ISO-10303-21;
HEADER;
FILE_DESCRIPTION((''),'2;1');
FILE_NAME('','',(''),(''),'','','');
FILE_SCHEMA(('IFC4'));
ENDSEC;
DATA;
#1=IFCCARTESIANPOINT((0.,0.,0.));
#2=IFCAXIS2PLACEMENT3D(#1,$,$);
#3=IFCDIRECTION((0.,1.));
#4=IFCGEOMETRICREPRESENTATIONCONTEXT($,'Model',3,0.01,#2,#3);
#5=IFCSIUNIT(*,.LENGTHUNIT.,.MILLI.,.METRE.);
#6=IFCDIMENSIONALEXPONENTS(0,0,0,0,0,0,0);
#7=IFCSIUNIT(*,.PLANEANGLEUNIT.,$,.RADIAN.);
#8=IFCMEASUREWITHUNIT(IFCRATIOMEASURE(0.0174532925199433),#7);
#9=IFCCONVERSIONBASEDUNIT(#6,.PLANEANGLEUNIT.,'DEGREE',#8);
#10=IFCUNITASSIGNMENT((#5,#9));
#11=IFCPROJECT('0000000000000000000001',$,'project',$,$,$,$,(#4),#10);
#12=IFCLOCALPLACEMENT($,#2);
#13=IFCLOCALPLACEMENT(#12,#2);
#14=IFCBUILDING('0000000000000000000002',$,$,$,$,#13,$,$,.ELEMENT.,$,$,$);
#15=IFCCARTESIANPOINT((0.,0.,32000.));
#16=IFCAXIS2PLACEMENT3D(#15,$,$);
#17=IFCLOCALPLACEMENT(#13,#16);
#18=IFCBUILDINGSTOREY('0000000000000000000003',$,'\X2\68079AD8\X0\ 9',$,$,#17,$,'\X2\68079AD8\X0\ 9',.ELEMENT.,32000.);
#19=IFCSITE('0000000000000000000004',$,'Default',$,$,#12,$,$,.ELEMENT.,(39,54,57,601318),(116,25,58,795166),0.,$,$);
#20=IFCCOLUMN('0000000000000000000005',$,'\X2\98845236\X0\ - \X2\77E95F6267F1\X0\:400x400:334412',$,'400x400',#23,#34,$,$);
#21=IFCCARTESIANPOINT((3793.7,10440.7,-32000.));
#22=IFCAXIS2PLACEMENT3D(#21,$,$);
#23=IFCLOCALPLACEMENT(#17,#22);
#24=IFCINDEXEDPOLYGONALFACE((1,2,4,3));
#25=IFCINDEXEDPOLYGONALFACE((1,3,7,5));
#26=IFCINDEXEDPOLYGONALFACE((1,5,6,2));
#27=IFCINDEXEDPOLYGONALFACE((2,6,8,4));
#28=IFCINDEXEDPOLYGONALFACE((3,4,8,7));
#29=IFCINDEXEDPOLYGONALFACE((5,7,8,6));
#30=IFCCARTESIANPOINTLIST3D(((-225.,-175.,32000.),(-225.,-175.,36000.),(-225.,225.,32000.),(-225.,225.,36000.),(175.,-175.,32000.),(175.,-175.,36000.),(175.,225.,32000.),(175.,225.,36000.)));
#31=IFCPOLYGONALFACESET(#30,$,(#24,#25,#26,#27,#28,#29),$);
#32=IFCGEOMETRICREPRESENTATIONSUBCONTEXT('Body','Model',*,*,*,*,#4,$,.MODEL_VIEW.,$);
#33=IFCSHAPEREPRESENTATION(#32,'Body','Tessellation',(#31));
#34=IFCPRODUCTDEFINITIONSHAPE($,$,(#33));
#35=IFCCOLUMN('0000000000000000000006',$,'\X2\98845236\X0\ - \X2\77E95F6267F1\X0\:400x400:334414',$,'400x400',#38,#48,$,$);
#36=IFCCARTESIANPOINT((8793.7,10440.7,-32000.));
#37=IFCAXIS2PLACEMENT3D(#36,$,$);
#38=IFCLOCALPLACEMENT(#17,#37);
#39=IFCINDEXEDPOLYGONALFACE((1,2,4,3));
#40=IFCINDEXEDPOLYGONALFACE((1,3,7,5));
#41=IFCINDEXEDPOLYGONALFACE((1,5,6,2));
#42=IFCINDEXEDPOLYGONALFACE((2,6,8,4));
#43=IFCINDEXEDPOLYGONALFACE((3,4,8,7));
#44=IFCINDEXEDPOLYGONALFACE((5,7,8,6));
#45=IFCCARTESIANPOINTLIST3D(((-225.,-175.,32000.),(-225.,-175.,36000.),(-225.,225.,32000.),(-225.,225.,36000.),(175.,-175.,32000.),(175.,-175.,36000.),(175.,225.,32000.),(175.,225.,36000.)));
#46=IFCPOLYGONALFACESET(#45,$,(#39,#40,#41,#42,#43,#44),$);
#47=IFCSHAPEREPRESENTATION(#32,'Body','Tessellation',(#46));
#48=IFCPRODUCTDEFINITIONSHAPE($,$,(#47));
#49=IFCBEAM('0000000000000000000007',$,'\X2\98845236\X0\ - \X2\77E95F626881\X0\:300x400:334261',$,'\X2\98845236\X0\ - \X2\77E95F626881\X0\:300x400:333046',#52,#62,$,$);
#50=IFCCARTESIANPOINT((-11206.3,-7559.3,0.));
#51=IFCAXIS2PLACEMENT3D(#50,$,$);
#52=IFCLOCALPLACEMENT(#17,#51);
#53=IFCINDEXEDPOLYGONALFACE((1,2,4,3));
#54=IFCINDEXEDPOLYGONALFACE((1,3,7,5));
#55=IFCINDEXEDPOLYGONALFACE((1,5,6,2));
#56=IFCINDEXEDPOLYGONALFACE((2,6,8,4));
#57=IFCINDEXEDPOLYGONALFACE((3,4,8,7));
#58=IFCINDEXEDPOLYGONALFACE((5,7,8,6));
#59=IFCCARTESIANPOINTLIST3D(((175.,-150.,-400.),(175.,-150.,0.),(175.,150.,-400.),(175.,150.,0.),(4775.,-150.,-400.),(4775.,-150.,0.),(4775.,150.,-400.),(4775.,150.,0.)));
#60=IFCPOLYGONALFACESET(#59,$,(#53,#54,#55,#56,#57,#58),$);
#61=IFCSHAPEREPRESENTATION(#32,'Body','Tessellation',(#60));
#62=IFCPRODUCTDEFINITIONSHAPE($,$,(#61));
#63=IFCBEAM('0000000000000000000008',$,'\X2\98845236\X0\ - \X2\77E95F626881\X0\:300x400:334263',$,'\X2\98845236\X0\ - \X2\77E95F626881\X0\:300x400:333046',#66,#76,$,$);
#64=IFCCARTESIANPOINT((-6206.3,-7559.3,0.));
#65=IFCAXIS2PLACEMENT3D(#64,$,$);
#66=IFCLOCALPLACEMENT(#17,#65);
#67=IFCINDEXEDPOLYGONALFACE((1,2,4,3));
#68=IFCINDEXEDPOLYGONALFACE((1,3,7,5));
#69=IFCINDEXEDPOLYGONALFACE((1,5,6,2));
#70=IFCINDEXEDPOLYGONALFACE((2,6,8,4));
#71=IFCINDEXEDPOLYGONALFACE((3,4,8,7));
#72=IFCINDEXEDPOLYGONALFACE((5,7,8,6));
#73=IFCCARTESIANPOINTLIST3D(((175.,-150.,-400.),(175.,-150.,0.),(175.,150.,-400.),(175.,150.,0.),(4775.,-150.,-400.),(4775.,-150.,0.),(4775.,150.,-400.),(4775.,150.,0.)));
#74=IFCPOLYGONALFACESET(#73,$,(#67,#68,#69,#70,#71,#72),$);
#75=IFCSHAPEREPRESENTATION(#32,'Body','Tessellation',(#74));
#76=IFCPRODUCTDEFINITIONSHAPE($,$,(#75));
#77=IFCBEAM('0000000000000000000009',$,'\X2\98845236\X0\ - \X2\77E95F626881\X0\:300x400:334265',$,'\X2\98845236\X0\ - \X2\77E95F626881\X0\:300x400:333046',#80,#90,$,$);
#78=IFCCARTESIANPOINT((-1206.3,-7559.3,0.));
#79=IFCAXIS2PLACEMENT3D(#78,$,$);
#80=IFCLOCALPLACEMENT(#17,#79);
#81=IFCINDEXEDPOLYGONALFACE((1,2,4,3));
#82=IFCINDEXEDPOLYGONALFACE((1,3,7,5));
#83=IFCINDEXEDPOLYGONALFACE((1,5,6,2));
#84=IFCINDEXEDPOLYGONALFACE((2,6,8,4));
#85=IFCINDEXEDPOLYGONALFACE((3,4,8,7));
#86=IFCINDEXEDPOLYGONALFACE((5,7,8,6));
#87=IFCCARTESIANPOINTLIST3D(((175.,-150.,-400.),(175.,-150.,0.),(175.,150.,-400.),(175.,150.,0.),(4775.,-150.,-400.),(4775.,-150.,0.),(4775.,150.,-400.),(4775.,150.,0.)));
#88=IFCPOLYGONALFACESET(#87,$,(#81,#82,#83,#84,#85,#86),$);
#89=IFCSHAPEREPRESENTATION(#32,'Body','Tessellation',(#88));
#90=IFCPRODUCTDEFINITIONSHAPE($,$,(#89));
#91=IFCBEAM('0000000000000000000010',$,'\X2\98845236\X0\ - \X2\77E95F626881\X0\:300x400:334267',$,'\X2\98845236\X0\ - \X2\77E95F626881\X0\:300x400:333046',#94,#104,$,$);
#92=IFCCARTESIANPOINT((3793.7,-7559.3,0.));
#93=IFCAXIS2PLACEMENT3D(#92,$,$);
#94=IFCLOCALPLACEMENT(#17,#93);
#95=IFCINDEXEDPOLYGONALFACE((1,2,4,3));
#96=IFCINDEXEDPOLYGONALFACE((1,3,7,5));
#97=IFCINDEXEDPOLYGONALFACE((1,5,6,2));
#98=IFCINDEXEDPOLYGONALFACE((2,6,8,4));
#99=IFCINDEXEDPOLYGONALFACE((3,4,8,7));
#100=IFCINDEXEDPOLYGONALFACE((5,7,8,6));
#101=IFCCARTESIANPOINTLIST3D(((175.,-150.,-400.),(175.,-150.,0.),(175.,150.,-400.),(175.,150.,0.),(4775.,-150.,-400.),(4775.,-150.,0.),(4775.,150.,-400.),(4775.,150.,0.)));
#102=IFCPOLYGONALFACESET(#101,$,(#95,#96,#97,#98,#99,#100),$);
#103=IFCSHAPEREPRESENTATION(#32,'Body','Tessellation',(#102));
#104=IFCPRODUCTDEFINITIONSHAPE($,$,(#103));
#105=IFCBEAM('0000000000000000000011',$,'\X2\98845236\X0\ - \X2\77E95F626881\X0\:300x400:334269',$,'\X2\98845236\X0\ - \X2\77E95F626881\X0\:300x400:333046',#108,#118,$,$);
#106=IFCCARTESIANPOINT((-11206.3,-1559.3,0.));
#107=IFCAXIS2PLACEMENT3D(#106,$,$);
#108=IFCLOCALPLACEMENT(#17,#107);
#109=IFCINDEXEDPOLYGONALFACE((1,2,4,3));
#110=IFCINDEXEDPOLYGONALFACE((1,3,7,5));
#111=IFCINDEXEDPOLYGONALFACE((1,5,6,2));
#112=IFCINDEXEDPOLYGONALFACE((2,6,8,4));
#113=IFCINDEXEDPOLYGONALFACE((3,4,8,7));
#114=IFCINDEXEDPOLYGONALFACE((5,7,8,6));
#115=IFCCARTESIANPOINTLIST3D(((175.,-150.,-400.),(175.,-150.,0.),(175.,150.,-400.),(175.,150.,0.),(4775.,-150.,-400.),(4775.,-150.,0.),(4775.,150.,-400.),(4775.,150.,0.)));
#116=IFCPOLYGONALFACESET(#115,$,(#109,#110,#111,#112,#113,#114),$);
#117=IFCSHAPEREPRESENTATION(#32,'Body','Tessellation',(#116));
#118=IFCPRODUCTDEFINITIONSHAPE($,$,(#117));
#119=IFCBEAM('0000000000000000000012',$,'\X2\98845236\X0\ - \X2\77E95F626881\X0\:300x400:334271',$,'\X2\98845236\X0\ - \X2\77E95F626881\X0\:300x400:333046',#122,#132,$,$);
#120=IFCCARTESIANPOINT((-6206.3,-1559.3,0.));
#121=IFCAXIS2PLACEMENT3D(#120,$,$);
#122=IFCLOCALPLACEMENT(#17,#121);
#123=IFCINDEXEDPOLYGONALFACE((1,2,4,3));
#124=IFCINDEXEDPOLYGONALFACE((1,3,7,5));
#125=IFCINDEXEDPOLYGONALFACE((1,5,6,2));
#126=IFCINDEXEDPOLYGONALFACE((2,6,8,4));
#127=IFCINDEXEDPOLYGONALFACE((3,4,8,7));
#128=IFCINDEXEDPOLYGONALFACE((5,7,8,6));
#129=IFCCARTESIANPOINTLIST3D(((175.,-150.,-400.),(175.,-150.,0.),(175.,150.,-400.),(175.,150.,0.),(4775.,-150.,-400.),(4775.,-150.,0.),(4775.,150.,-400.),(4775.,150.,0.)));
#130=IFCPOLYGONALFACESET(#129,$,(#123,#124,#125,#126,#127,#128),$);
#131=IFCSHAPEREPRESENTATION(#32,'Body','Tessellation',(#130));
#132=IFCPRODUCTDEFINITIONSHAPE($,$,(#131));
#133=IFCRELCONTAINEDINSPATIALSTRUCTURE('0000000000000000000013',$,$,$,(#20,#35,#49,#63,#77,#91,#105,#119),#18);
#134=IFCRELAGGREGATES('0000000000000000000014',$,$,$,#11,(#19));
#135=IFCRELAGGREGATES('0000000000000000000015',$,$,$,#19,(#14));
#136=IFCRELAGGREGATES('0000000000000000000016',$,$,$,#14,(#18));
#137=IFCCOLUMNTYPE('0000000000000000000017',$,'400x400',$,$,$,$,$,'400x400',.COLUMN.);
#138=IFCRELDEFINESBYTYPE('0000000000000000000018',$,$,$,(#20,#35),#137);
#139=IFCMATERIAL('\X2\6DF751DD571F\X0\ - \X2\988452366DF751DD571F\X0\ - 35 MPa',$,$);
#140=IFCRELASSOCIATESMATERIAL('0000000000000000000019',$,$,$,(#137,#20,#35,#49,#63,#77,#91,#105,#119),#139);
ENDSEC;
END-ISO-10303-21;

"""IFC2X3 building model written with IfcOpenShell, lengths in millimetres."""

from ifc_helpers import new_model, entity, si_unit, converted_unit, direction, frame, frame_2d, origin, place, context, subcontext, project, spatial, rectangle, extrude, source, transform, mapped, material, type_object, type_shapes, element, save


model = new_model("IFC2X3")

# Units and contexts
model_context = context("Model", 3, precision=0.01, world=origin(), true_north=direction((0.0, 1.0)))
body_context = subcontext(model_context, "Body", "Model", "MODEL_VIEW")
ifc_project = project(units=[si_unit("LENGTHUNIT", "METRE", prefix="MILLI"), converted_unit("PLANEANGLEUNIT", "DEGREE", entity("IfcRatioMeasure", 0.0174532925199433), si_unit("PLANEANGLEUNIT", "RADIAN"), dimensions=[0, 0, 0, 0, 0, 0, 0])], contexts=[model_context])

# Site, building, storey
site_placement = place(None, origin())
site = spatial("IfcSite", under=ifc_project, at=site_placement, Name="Default", CompositionType="ELEMENT", RefLatitude=(39, 54, 57, 601318), RefLongitude=(116, 25, 58, 795166), RefElevation=0.0)
building_placement = place(site_placement, origin())
building = spatial("IfcBuilding", under=site, at=building_placement, CompositionType="ELEMENT")
storey_placement = place(building_placement, frame((0.0, 0.0, 32000.0)))
storey = spatial("IfcBuildingStorey", under=building, at=storey_placement, Name="标高 9", LongName="标高 9", CompositionType="ELEMENT", Elevation=32000.0)

# Columns
ifc_material = material(Name="混凝土 - 预制混凝土 - 35 MPa")
column_type = type_object("IfcColumnType", Name="400x400", ElementType="400x400", PredefinedType="COLUMN", material=ifc_material)
shared_shape = source(origin(), body_context, "Body", "SweptSolid", [
    extrude(rectangle(XDim=400.0, YDim=400.0, at=frame_2d((0.0, 0.0), x_axis=(1.0, 0.0))), frame((-25.0, 25.0, 32000.0)), (0.0, 0.0, 1.0), 4000.0),
])
type_shapes(column_type, [shared_shape])
for number, where, name in (
    (1, (3793.7, 10440.7, -32000.0), "预制 - 矩形柱:400x400:334412"),
    (2, (8793.7, 10440.7, -32000.0), "预制 - 矩形柱:400x400:334414"),
):
    element("IfcColumn", number, at=place(storey_placement, frame(where)), inside=storey, type_object=column_type, material=ifc_material, Name=name, ObjectType="400x400", context=body_context, shape_type="MappedRepresentation", body=[
        mapped(shared_shape, transform((0.0, 0.0, 0.0), scale=1.0)),
    ])

# Beams
for number, where, name in (
    (3, (-11206.3, -7559.3, 0.0), "预制 - 矩形梁:300x400:334261"),
    (4, (-6206.3, -7559.3, 0.0), "预制 - 矩形梁:300x400:334263"),
):
    element("IfcBeam", number, at=place(storey_placement, frame(where)), inside=storey, material=ifc_material, Name=name, ObjectType="预制 - 矩形梁:300x400:333046", context=body_context, shape_type="SweptSolid", body=[
        extrude(rectangle(XDim=400.0, YDim=300.0, at=frame_2d((0.0, 0.0), x_axis=(1.0, 0.0))), frame((175.0, 0.0, -200.0), z_axis=(1.0, 0.0, 0.0), x_axis=(0.0, 0.0, -1.0)), (0.0, 0.0, 1.0), 4600.0),
    ])
for number, where, name in (
    (5, (-1206.3, -7559.3, 0.0), "预制 - 矩形梁:300x400:334265"),
    (6, (3793.7, -7559.3, 0.0), "预制 - 矩形梁:300x400:334267"),
):
    element("IfcBeam", number, at=place(storey_placement, frame(where)), inside=storey, material=ifc_material, Name=name, ObjectType="预制 - 矩形梁:300x400:333046", context=body_context, shape_type="SweptSolid", body=[
        extrude(rectangle(XDim=400.0, YDim=300.0, at=frame_2d((0.0, 0.0), x_axis=(1.0, 0.0))), frame((175.0, 0.0, -200.0), z_axis=(1.0, 0.0, 0.0), x_axis=(0.0, 0.0, -1.0)), (0.0, 0.0, 1.0), 4600.0),
    ])
for number, where, name in (
    (7, (-11206.3, -1559.3, 0.0), "预制 - 矩形梁:300x400:334269"),
    (8, (-6206.3, -1559.3, 0.0), "预制 - 矩形梁:300x400:334271"),
):
    element("IfcBeam", number, at=place(storey_placement, frame(where)), inside=storey, material=ifc_material, Name=name, ObjectType="预制 - 矩形梁:300x400:333046", context=body_context, shape_type="SweptSolid", body=[
        extrude(rectangle(XDim=400.0, YDim=300.0, at=frame_2d((0.0, 0.0), x_axis=(1.0, 0.0))), frame((175.0, 0.0, -200.0), z_axis=(1.0, 0.0, 0.0), x_axis=(0.0, 0.0, -1.0)), (0.0, 0.0, 1.0), 4600.0),
    ])

save(model, "model.ifc")
